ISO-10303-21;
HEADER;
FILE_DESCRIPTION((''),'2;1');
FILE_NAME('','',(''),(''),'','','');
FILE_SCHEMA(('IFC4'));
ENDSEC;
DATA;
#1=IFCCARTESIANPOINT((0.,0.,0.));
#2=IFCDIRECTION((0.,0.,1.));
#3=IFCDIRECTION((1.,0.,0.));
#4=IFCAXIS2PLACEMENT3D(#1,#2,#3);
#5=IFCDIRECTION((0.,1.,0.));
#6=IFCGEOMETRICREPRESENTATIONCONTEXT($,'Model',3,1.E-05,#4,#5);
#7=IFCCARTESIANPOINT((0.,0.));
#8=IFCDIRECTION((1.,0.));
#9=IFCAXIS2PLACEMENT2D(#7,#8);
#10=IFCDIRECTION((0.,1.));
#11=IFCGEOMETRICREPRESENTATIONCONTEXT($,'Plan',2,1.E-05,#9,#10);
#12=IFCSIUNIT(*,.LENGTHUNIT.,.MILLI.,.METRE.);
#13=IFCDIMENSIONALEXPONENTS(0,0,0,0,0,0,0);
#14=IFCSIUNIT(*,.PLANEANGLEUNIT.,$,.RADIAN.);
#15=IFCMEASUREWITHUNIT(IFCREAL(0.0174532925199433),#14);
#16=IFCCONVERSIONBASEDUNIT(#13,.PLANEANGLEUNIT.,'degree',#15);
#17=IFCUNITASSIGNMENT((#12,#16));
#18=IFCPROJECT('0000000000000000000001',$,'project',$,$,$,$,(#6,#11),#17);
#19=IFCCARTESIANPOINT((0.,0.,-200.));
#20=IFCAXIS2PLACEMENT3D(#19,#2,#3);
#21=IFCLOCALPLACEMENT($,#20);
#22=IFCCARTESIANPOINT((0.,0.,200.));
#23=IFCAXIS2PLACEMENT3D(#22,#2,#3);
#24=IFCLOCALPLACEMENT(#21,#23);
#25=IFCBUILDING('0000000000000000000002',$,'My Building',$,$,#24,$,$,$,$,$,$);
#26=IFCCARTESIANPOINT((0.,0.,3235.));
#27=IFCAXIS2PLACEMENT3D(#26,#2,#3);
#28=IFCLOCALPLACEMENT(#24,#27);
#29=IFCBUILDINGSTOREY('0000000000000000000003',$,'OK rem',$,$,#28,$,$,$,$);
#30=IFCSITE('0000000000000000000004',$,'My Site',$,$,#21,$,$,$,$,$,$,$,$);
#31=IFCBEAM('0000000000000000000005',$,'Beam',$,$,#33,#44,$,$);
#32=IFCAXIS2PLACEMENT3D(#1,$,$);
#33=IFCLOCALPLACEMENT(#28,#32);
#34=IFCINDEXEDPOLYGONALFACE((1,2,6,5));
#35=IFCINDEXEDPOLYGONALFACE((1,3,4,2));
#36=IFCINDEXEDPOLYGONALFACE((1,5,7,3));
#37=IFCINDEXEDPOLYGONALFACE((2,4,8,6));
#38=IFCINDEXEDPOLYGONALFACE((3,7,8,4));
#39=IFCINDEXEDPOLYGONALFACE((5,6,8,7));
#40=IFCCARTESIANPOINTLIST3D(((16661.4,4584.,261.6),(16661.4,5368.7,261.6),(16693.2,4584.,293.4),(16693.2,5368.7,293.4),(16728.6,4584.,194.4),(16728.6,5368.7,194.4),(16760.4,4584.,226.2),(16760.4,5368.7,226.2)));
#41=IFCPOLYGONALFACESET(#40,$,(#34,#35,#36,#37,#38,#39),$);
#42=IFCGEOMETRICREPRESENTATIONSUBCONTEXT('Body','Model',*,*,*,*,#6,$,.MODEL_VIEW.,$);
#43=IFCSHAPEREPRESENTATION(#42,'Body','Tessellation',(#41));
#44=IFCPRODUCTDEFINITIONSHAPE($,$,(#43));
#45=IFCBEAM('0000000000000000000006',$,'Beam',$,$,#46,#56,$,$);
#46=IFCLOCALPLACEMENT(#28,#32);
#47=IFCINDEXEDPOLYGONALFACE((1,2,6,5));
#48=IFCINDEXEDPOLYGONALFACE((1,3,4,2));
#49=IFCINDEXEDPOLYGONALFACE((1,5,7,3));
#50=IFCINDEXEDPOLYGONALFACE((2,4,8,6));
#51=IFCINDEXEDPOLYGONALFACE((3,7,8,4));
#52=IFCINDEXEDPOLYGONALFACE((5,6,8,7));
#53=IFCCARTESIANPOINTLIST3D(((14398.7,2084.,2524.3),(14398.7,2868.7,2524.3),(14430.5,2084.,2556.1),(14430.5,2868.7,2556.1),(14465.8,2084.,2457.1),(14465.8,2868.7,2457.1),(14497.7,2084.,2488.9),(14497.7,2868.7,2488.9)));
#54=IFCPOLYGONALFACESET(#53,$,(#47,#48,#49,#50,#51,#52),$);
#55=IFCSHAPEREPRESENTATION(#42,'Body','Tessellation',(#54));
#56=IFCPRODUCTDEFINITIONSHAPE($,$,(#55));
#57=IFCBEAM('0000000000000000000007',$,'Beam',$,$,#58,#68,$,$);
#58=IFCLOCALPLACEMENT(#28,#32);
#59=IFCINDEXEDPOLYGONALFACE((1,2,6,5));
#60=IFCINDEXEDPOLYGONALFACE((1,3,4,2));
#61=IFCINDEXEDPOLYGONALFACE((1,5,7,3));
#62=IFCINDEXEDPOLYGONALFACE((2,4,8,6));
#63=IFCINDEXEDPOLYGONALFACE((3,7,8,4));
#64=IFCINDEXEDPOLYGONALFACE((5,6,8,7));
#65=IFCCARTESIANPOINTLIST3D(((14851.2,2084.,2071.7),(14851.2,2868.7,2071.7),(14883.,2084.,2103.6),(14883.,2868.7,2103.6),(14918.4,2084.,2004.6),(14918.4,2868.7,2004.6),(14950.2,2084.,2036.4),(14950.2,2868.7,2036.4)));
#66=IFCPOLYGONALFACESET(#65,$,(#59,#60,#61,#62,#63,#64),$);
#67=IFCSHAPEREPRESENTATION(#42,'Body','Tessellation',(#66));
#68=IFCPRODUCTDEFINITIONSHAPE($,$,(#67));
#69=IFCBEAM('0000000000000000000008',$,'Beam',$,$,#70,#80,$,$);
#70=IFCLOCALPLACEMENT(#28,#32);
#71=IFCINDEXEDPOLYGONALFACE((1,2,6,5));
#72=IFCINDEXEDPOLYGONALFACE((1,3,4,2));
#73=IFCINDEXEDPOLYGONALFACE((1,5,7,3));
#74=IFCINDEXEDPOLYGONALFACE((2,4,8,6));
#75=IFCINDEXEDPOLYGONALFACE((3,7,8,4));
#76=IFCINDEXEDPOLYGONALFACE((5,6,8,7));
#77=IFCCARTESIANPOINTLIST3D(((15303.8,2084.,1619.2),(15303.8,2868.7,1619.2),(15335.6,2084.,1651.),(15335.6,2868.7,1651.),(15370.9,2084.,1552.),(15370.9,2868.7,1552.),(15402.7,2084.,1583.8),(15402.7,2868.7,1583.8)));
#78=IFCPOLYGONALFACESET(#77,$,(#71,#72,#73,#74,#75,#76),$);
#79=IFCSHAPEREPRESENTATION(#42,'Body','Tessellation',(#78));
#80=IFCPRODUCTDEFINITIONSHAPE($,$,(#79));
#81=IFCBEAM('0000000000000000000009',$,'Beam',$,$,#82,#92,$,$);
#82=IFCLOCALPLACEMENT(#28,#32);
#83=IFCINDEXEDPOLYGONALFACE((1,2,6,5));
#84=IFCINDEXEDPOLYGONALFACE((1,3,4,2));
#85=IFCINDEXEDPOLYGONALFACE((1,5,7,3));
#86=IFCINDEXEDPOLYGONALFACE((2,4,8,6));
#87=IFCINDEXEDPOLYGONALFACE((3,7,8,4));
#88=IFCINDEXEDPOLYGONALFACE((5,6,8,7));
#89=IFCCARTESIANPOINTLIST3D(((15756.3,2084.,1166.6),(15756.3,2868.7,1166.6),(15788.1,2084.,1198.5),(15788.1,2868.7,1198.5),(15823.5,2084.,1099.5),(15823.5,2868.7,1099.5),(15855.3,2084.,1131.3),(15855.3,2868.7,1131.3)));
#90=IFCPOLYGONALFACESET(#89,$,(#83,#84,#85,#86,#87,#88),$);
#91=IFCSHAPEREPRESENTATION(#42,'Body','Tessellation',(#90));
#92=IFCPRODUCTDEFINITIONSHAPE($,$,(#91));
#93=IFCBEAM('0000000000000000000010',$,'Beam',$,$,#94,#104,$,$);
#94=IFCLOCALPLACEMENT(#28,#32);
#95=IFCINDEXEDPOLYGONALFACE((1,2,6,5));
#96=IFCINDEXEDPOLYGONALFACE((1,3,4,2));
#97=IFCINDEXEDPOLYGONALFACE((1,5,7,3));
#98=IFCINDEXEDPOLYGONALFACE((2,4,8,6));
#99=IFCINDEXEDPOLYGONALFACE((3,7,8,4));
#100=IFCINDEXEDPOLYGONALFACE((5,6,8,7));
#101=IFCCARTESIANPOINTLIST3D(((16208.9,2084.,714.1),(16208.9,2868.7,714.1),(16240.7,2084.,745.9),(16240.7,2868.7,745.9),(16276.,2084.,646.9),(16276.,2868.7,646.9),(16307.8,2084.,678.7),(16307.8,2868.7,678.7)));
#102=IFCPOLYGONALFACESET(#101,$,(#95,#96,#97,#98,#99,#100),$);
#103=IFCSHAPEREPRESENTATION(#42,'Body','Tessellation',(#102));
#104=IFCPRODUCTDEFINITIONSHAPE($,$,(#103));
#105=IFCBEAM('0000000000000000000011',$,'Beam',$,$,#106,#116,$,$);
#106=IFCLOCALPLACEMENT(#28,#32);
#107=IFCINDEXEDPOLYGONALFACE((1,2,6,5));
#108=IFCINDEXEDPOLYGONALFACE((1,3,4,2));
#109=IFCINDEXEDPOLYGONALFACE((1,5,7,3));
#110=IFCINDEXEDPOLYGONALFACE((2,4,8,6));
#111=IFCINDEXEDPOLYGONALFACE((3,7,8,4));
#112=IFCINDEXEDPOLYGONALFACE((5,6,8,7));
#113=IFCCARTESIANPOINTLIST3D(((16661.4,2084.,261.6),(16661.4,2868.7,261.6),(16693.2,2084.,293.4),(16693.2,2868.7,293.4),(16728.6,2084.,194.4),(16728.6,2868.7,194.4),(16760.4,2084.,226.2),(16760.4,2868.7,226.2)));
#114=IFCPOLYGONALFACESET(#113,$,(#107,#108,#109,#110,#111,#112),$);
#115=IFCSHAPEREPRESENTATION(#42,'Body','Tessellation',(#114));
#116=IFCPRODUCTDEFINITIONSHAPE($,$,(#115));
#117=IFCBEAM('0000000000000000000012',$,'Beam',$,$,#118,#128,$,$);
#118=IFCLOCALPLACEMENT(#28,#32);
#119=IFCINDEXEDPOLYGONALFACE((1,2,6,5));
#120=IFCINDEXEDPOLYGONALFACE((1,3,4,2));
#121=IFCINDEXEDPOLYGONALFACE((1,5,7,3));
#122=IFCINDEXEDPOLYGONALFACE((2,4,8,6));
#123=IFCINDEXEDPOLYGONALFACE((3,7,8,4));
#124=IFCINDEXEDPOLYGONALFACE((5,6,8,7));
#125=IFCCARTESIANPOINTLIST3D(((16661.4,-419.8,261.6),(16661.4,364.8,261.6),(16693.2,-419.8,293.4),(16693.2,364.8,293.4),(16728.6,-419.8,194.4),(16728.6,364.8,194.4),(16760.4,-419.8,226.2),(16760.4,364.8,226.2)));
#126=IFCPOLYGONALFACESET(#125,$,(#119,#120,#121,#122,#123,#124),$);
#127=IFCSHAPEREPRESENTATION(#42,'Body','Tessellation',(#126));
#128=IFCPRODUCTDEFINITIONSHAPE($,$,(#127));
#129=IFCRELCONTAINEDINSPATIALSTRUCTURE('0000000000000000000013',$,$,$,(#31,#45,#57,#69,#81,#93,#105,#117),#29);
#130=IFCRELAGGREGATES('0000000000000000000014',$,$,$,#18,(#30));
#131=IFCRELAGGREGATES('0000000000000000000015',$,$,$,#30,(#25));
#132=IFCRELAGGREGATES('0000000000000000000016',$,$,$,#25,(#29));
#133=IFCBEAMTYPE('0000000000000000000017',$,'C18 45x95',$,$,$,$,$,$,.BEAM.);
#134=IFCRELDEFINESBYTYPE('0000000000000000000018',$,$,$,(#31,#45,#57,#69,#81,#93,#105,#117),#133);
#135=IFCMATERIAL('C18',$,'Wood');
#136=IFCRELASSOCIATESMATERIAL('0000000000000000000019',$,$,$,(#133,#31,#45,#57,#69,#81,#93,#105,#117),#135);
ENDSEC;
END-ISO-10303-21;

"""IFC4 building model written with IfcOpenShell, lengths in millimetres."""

from ifc_helpers import new_model, entity, si_unit, converted_unit, direction, frame, origin_with_axes, origin_2d_with_axis, place, context, subcontext, project, spatial, rectangle, extrude, material, material_profile, profile_set, profile_usage, type_object, element, save


model = new_model("IFC4")

# Units and contexts
model_context = context("Model", 3, precision=1e-05, world=origin_with_axes(), true_north=direction((0.0, 1.0, 0.0)))
plan_context = context("Plan", 2, precision=1e-05, world=origin_2d_with_axis(), true_north=direction((0.0, 1.0)))
body_context = subcontext(model_context, "Body", "Model", "MODEL_VIEW")
ifc_project = project(units=[si_unit("LENGTHUNIT", "METRE", prefix="MILLI"), converted_unit("PLANEANGLEUNIT", "degree", entity("IfcReal", 0.0174532925199433), si_unit("PLANEANGLEUNIT", "RADIAN"), dimensions=[0, 0, 0, 0, 0, 0, 0])], contexts=[model_context, plan_context])

# Site, building, storey
site_placement = place(None, frame((0.0, 0.0, -200.0), z_axis=(0.0, 0.0, 1.0), x_axis=(1.0, 0.0, 0.0)))
site = spatial("IfcSite", under=ifc_project, at=site_placement, Name="My Site")
building_placement = place(site_placement, frame((0.0, 0.0, 200.0), z_axis=(0.0, 0.0, 1.0), x_axis=(1.0, 0.0, 0.0)))
building = spatial("IfcBuilding", under=site, at=building_placement, Name="My Building")
storey_placement = place(building_placement, frame((0.0, 0.0, 3235.0), z_axis=(0.0, 0.0, 1.0), x_axis=(1.0, 0.0, 0.0)))
storey = spatial("IfcBuildingStorey", under=building, at=storey_placement, Name="OK rem")

# Beams
ifc_material = material(Name="C18", Category="Wood")
ifc_material_profile = material_profile(ifc_material, rectangle(XDim=45.0, YDim=95.0))
ifc_profile_set = profile_set([ifc_material_profile], Name="woodStructural")
beam_type = type_object("IfcBeamType", Name="C18 45x95", PredefinedType="BEAM", material=ifc_profile_set)
ifc_profile_usage_1 = profile_usage(ifc_profile_set, cardinal=5)
beam_1_placement = place(storey_placement, frame((16710.9, 4584.0, 243.9), z_axis=(0.0, 1.0, 0.0), x_axis=(-0.707107, 0.0, -0.707107)))
element("IfcBeam", 1, at=beam_1_placement, inside=storey, type_object=beam_type, material=ifc_profile_usage_1, Name="Beam", context=body_context, shape_type="SweptSolid", body=[
    extrude(rectangle(XDim=45.0, YDim=95.0), origin_with_axes(), (0.0, 0.0, 1.0), 784.6),
])
ifc_profile_usage_2 = profile_usage(ifc_profile_set, cardinal=5)
beam_2_placement = place(storey_placement, frame((14448.2, 2084.0, 2506.6), z_axis=(0.0, 1.0, 0.0), x_axis=(-0.707107, 0.0, -0.707107)))
element("IfcBeam", 2, at=beam_2_placement, inside=storey, type_object=beam_type, material=ifc_profile_usage_2, Name="Beam", context=body_context, shape_type="SweptSolid", body=[
    extrude(rectangle(XDim=45.0, YDim=95.0), origin_with_axes(), (0.0, 0.0, 1.0), 784.6),
])
ifc_profile_usage_3 = profile_usage(ifc_profile_set, cardinal=5)
beam_3_placement = place(storey_placement, frame((14900.7, 2084.0, 2054.1), z_axis=(0.0, 1.0, 0.0), x_axis=(-0.707107, 0.0, -0.707107)))
element("IfcBeam", 3, at=beam_3_placement, inside=storey, type_object=beam_type, material=ifc_profile_usage_3, Name="Beam", context=body_context, shape_type="SweptSolid", body=[
    extrude(rectangle(XDim=45.0, YDim=95.0), origin_with_axes(), (0.0, 0.0, 1.0), 784.6),
])
ifc_profile_usage_4 = profile_usage(ifc_profile_set, cardinal=5)
beam_4_placement = place(storey_placement, frame((15353.3, 2084.0, 1601.5), z_axis=(0.0, 1.0, 0.0), x_axis=(-0.707107, 0.0, -0.707107)))
element("IfcBeam", 4, at=beam_4_placement, inside=storey, type_object=beam_type, material=ifc_profile_usage_4, Name="Beam", context=body_context, shape_type="SweptSolid", body=[
    extrude(rectangle(XDim=45.0, YDim=95.0), origin_with_axes(), (0.0, 0.0, 1.0), 784.6),
])
ifc_profile_usage_5 = profile_usage(ifc_profile_set, cardinal=5)
beam_5_placement = place(storey_placement, frame((15805.8, 2084.0, 1149.0), z_axis=(0.0, 1.0, 0.0), x_axis=(-0.707107, 0.0, -0.707107)))
element("IfcBeam", 5, at=beam_5_placement, inside=storey, type_object=beam_type, material=ifc_profile_usage_5, Name="Beam", context=body_context, shape_type="SweptSolid", body=[
    extrude(rectangle(XDim=45.0, YDim=95.0), origin_with_axes(), (0.0, 0.0, 1.0), 784.6),
])
ifc_profile_usage_6 = profile_usage(ifc_profile_set, cardinal=5)
beam_6_placement = place(storey_placement, frame((16258.3, 2084.0, 696.4), z_axis=(0.0, 1.0, 0.0), x_axis=(-0.707107, 0.0, -0.707107)))
element("IfcBeam", 6, at=beam_6_placement, inside=storey, type_object=beam_type, material=ifc_profile_usage_6, Name="Beam", context=body_context, shape_type="SweptSolid", body=[
    extrude(rectangle(XDim=45.0, YDim=95.0), origin_with_axes(), (0.0, 0.0, 1.0), 784.6),
])
ifc_profile_usage_7 = profile_usage(ifc_profile_set, cardinal=5)
beam_7_placement = place(storey_placement, frame((16710.9, 2084.0, 243.9), z_axis=(0.0, 1.0, 0.0), x_axis=(-0.707107, 0.0, -0.707107)))
element("IfcBeam", 7, at=beam_7_placement, inside=storey, type_object=beam_type, material=ifc_profile_usage_7, Name="Beam", context=body_context, shape_type="SweptSolid", body=[
    extrude(rectangle(XDim=45.0, YDim=95.0), origin_with_axes(), (0.0, 0.0, 1.0), 784.6),
])
ifc_profile_usage_8 = profile_usage(ifc_profile_set, cardinal=5)
beam_8_placement = place(storey_placement, frame((16710.9, -419.8, 243.9), z_axis=(0.0, 1.0, 0.0), x_axis=(-0.707107, 0.0, -0.707107)))
element("IfcBeam", 8, at=beam_8_placement, inside=storey, type_object=beam_type, material=ifc_profile_usage_8, Name="Beam", context=body_context, shape_type="SweptSolid", body=[
    extrude(rectangle(XDim=45.0, YDim=95.0), origin_with_axes(), (0.0, 0.0, 1.0), 784.6),
])

save(model, "model.ifc")
